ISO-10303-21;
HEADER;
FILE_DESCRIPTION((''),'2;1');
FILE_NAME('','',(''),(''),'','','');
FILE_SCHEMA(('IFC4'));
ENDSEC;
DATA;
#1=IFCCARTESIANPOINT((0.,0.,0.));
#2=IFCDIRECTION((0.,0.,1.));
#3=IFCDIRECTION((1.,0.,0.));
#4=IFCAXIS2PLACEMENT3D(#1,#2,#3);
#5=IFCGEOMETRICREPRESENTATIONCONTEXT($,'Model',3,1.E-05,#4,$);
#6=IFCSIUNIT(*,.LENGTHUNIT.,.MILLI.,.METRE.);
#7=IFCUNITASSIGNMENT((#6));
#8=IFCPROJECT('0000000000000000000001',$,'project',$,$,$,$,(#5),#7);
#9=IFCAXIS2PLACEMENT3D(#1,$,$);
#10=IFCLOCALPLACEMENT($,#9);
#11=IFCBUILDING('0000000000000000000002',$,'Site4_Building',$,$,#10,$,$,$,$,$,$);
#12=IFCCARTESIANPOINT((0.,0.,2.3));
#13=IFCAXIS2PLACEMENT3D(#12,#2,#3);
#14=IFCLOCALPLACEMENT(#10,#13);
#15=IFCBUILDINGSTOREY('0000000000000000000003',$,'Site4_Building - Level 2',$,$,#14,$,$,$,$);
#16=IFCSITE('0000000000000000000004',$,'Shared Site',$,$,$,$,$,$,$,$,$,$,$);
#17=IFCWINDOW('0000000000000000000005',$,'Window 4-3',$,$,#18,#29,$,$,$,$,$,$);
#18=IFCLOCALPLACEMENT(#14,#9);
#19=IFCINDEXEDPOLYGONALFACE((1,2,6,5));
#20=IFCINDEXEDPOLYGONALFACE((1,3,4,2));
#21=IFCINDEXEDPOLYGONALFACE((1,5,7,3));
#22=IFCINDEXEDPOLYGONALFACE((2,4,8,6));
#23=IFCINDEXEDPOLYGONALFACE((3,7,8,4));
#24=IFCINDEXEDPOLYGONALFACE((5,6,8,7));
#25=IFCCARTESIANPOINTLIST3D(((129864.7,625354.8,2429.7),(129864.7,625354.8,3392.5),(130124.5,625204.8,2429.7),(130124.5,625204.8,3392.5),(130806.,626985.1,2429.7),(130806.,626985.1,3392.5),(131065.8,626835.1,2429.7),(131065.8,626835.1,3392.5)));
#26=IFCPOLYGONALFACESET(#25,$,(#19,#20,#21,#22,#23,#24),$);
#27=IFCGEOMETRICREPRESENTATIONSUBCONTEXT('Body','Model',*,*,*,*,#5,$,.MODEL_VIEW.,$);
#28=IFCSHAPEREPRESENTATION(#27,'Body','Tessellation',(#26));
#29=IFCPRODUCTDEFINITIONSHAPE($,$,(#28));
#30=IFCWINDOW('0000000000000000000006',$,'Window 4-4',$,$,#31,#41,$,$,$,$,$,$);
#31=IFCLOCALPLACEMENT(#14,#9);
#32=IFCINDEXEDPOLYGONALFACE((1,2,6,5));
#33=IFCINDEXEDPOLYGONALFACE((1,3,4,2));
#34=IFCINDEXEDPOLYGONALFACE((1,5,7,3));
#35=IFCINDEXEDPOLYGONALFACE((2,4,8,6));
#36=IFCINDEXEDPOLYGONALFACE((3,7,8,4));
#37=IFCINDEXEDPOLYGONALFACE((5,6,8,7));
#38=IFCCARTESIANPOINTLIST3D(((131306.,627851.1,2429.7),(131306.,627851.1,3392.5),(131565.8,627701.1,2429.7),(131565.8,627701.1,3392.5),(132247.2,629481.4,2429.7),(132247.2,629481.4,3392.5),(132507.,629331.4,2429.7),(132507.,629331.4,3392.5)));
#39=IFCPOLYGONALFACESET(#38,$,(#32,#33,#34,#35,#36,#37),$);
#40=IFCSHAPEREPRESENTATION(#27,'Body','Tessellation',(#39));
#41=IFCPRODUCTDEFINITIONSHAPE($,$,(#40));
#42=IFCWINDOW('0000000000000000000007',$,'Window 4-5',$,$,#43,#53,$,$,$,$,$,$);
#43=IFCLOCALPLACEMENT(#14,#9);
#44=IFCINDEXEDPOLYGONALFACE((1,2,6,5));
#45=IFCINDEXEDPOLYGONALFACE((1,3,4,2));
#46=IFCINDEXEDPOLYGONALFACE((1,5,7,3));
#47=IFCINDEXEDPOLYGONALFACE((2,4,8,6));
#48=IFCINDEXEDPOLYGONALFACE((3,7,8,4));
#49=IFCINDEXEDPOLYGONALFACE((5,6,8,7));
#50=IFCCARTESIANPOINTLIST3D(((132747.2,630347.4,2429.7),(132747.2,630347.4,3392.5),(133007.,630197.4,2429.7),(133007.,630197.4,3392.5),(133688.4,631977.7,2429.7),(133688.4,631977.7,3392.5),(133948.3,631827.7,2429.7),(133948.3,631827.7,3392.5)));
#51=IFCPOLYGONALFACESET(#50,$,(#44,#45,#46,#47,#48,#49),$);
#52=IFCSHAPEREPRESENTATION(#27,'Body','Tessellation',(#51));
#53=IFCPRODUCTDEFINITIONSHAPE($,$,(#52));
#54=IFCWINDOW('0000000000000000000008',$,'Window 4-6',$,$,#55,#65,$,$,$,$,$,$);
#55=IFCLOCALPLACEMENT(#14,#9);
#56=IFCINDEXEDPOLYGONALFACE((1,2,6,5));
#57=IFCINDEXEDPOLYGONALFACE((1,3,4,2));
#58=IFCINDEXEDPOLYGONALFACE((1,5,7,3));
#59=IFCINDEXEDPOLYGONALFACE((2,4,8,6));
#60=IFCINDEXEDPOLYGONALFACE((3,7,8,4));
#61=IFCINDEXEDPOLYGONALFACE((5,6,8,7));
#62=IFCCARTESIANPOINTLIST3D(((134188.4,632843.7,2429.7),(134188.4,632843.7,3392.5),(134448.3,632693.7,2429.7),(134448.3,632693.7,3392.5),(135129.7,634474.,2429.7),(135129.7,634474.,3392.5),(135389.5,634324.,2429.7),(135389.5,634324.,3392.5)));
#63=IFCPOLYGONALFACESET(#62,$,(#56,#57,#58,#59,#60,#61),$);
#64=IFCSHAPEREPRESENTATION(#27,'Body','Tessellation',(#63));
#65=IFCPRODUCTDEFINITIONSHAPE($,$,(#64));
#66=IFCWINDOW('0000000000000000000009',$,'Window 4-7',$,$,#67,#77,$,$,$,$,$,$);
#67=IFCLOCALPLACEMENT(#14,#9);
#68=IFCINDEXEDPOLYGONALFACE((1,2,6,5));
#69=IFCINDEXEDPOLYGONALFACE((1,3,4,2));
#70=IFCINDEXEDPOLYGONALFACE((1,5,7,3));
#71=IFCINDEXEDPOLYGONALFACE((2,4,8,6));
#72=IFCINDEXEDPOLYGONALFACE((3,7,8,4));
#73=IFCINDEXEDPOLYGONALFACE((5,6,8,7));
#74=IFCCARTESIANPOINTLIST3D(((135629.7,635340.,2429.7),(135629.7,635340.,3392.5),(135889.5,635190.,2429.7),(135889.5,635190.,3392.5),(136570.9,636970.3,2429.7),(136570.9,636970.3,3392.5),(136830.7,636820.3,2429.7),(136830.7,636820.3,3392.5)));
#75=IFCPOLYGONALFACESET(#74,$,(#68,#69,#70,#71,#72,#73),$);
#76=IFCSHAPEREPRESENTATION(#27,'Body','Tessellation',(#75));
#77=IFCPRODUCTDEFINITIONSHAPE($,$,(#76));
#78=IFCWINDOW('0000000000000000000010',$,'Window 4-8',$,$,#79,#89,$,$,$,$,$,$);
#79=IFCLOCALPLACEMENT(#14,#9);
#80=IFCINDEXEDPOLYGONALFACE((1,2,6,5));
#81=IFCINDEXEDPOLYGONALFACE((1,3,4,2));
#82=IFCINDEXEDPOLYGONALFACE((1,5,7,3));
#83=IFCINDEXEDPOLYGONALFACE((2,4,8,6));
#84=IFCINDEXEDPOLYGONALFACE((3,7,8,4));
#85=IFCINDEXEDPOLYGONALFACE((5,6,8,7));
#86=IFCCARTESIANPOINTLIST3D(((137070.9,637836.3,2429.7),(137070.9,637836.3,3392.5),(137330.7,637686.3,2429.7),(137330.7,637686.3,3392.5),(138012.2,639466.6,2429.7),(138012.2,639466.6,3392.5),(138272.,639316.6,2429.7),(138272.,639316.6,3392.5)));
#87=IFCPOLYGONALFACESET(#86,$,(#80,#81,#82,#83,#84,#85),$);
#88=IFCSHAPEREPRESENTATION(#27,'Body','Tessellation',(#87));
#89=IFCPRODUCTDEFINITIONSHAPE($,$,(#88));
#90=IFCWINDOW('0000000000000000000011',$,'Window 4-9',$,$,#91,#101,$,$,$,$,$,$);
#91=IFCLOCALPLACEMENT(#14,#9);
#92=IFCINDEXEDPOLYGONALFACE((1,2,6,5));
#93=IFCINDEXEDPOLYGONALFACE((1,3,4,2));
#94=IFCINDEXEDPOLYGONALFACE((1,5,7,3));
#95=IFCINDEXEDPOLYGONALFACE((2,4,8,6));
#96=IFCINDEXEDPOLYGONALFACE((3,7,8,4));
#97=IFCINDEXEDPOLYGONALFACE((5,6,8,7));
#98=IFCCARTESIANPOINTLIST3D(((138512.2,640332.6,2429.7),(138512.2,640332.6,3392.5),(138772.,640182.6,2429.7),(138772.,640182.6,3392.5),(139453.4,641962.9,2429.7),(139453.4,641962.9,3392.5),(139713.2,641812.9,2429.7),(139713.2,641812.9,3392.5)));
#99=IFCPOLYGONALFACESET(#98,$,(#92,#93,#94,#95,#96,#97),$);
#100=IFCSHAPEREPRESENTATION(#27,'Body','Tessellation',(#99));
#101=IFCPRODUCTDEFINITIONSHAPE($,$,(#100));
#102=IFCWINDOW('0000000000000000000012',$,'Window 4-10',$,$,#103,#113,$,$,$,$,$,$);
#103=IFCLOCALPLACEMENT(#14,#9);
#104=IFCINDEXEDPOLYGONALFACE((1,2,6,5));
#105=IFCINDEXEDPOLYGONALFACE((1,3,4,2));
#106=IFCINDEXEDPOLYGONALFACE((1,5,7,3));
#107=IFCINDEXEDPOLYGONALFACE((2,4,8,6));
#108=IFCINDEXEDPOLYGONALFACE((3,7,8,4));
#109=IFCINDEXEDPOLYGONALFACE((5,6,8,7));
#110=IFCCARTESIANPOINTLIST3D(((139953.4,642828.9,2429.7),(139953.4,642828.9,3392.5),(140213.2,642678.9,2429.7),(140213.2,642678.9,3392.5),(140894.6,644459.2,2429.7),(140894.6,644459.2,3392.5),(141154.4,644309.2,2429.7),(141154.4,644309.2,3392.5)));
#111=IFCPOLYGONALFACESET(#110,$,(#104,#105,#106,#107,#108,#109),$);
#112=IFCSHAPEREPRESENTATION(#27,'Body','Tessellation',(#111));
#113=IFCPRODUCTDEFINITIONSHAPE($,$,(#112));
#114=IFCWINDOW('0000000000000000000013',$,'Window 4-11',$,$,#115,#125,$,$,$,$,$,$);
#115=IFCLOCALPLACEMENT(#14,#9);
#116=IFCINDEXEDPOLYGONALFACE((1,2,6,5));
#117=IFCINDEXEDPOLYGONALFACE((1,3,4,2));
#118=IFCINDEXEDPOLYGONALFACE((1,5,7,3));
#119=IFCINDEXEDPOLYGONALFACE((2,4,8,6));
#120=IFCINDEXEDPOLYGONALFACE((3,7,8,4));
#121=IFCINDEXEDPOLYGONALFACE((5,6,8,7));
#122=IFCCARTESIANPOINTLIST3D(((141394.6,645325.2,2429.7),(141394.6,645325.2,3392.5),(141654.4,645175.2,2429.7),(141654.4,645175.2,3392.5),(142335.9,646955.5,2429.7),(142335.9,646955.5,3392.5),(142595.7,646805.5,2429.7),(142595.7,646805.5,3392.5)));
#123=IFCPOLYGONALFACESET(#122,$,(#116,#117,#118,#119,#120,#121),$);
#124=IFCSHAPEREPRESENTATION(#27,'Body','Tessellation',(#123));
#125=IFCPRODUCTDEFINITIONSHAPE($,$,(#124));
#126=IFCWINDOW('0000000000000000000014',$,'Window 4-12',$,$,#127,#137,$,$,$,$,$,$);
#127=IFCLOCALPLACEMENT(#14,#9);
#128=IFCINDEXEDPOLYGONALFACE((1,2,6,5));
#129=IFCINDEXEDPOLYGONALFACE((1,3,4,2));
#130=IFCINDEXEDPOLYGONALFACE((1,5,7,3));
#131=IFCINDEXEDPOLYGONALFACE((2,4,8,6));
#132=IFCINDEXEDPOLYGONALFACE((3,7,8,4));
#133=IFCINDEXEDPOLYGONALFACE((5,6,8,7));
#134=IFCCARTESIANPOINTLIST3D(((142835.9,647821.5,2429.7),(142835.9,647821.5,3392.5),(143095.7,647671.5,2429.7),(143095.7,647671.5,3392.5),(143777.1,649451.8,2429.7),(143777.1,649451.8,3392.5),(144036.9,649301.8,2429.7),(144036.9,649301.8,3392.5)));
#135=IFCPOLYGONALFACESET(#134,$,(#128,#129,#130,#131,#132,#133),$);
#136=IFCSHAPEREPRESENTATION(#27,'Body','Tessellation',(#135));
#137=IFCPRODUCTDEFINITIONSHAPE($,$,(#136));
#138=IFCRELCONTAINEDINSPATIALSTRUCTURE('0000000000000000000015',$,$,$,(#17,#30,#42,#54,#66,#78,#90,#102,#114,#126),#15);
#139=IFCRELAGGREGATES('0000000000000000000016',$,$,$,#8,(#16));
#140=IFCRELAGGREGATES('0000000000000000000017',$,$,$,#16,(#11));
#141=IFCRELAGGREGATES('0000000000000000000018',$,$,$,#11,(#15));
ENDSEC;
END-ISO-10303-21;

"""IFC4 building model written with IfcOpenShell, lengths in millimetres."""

from ifc_helpers import new_model, si_unit, frame, origin, origin_with_axes, place, context, subcontext, project, spatial, indexed_curve, outline, extrude, element, save


model = new_model("IFC4")

# Units and contexts
model_context = context("Model", 3, precision=1e-05, world=origin_with_axes())
body_context = subcontext(model_context, "Body", "Model", "MODEL_VIEW")
ifc_project = project(units=[si_unit("LENGTHUNIT", "METRE", prefix="MILLI")], contexts=[model_context])

# Site, building, storey
site = spatial("IfcSite", under=ifc_project, Name="Shared Site")
building_placement = place(None, origin())
building = spatial("IfcBuilding", under=site, at=building_placement, Name="Site4_Building")
storey_placement = place(building_placement, frame((0.0, 0.0, 2.3), z_axis=(0.0, 0.0, 1.0), x_axis=(1.0, 0.0, 0.0)))
storey = spatial("IfcBuildingStorey", under=building, at=storey_placement, Name="Site4_Building - Level 2")

# Windows
for number, where, z_axis, x_axis, name in (
    (1, (130124.5, 625204.8, 2429.7), (0.0, 0.0, 1.0), (0.5, 0.866025, 0.0), "Window 4-3"),
    (2, (131565.8, 627701.1, 2429.7), (0.0, 0.0, 1.0), (0.5, 0.866025, 0.0), "Window 4-4"),
    (3, (133007.0, 630197.4, 2429.7), (0.0, 0.0, 1.0), (0.5, 0.866025, 0.0), "Window 4-5"),
    (4, (134448.3, 632693.7, 2429.7), (0.0, 0.0, 1.0), (0.5, 0.866025, 0.0), "Window 4-6"),
    (5, (135889.5, 635190.0, 2429.7), (0.0, 0.0, 1.0), (0.5, 0.866025, 0.0), "Window 4-7"),
    (6, (137330.7, 637686.3, 2429.7), (0.0, 0.0, 1.0), (0.5, 0.866025, 0.0), "Window 4-8"),
    (7, (138772.0, 640182.6, 2429.7), (0.0, 0.0, 1.0), (0.5, 0.866025, 0.0), "Window 4-9"),
    (8, (140213.2, 642678.9, 2429.7), (0.0, 0.0, 1.0), (0.5, 0.866025, 0.0), "Window 4-10"),
    (9, (141654.4, 645175.2, 2429.7), (0.0, 0.0, 1.0), (0.5, 0.866025, 0.0), "Window 4-11"),
    (10, (143095.7, 647671.5, 2429.7), (0.0, 0.0, 1.0), (0.5, 0.866025, 0.0), "Window 4-12"),
):
    element("IfcWindow", number, at=place(storey_placement, frame(where, z_axis=z_axis, x_axis=x_axis)), inside=storey, Name=name, context=body_context, shape_type="SweptSolid", body=[
        extrude(outline(indexed_curve([(0.0, 0.0), (0.0, 300.0), (1882.5, 300.0), (1882.5, 0.0), (0.0, 0.0)], self_intersect=False)), origin_with_axes(), (0.0, 0.0, 1.0), 962.8),
    ])

save(model, "model.ifc")
